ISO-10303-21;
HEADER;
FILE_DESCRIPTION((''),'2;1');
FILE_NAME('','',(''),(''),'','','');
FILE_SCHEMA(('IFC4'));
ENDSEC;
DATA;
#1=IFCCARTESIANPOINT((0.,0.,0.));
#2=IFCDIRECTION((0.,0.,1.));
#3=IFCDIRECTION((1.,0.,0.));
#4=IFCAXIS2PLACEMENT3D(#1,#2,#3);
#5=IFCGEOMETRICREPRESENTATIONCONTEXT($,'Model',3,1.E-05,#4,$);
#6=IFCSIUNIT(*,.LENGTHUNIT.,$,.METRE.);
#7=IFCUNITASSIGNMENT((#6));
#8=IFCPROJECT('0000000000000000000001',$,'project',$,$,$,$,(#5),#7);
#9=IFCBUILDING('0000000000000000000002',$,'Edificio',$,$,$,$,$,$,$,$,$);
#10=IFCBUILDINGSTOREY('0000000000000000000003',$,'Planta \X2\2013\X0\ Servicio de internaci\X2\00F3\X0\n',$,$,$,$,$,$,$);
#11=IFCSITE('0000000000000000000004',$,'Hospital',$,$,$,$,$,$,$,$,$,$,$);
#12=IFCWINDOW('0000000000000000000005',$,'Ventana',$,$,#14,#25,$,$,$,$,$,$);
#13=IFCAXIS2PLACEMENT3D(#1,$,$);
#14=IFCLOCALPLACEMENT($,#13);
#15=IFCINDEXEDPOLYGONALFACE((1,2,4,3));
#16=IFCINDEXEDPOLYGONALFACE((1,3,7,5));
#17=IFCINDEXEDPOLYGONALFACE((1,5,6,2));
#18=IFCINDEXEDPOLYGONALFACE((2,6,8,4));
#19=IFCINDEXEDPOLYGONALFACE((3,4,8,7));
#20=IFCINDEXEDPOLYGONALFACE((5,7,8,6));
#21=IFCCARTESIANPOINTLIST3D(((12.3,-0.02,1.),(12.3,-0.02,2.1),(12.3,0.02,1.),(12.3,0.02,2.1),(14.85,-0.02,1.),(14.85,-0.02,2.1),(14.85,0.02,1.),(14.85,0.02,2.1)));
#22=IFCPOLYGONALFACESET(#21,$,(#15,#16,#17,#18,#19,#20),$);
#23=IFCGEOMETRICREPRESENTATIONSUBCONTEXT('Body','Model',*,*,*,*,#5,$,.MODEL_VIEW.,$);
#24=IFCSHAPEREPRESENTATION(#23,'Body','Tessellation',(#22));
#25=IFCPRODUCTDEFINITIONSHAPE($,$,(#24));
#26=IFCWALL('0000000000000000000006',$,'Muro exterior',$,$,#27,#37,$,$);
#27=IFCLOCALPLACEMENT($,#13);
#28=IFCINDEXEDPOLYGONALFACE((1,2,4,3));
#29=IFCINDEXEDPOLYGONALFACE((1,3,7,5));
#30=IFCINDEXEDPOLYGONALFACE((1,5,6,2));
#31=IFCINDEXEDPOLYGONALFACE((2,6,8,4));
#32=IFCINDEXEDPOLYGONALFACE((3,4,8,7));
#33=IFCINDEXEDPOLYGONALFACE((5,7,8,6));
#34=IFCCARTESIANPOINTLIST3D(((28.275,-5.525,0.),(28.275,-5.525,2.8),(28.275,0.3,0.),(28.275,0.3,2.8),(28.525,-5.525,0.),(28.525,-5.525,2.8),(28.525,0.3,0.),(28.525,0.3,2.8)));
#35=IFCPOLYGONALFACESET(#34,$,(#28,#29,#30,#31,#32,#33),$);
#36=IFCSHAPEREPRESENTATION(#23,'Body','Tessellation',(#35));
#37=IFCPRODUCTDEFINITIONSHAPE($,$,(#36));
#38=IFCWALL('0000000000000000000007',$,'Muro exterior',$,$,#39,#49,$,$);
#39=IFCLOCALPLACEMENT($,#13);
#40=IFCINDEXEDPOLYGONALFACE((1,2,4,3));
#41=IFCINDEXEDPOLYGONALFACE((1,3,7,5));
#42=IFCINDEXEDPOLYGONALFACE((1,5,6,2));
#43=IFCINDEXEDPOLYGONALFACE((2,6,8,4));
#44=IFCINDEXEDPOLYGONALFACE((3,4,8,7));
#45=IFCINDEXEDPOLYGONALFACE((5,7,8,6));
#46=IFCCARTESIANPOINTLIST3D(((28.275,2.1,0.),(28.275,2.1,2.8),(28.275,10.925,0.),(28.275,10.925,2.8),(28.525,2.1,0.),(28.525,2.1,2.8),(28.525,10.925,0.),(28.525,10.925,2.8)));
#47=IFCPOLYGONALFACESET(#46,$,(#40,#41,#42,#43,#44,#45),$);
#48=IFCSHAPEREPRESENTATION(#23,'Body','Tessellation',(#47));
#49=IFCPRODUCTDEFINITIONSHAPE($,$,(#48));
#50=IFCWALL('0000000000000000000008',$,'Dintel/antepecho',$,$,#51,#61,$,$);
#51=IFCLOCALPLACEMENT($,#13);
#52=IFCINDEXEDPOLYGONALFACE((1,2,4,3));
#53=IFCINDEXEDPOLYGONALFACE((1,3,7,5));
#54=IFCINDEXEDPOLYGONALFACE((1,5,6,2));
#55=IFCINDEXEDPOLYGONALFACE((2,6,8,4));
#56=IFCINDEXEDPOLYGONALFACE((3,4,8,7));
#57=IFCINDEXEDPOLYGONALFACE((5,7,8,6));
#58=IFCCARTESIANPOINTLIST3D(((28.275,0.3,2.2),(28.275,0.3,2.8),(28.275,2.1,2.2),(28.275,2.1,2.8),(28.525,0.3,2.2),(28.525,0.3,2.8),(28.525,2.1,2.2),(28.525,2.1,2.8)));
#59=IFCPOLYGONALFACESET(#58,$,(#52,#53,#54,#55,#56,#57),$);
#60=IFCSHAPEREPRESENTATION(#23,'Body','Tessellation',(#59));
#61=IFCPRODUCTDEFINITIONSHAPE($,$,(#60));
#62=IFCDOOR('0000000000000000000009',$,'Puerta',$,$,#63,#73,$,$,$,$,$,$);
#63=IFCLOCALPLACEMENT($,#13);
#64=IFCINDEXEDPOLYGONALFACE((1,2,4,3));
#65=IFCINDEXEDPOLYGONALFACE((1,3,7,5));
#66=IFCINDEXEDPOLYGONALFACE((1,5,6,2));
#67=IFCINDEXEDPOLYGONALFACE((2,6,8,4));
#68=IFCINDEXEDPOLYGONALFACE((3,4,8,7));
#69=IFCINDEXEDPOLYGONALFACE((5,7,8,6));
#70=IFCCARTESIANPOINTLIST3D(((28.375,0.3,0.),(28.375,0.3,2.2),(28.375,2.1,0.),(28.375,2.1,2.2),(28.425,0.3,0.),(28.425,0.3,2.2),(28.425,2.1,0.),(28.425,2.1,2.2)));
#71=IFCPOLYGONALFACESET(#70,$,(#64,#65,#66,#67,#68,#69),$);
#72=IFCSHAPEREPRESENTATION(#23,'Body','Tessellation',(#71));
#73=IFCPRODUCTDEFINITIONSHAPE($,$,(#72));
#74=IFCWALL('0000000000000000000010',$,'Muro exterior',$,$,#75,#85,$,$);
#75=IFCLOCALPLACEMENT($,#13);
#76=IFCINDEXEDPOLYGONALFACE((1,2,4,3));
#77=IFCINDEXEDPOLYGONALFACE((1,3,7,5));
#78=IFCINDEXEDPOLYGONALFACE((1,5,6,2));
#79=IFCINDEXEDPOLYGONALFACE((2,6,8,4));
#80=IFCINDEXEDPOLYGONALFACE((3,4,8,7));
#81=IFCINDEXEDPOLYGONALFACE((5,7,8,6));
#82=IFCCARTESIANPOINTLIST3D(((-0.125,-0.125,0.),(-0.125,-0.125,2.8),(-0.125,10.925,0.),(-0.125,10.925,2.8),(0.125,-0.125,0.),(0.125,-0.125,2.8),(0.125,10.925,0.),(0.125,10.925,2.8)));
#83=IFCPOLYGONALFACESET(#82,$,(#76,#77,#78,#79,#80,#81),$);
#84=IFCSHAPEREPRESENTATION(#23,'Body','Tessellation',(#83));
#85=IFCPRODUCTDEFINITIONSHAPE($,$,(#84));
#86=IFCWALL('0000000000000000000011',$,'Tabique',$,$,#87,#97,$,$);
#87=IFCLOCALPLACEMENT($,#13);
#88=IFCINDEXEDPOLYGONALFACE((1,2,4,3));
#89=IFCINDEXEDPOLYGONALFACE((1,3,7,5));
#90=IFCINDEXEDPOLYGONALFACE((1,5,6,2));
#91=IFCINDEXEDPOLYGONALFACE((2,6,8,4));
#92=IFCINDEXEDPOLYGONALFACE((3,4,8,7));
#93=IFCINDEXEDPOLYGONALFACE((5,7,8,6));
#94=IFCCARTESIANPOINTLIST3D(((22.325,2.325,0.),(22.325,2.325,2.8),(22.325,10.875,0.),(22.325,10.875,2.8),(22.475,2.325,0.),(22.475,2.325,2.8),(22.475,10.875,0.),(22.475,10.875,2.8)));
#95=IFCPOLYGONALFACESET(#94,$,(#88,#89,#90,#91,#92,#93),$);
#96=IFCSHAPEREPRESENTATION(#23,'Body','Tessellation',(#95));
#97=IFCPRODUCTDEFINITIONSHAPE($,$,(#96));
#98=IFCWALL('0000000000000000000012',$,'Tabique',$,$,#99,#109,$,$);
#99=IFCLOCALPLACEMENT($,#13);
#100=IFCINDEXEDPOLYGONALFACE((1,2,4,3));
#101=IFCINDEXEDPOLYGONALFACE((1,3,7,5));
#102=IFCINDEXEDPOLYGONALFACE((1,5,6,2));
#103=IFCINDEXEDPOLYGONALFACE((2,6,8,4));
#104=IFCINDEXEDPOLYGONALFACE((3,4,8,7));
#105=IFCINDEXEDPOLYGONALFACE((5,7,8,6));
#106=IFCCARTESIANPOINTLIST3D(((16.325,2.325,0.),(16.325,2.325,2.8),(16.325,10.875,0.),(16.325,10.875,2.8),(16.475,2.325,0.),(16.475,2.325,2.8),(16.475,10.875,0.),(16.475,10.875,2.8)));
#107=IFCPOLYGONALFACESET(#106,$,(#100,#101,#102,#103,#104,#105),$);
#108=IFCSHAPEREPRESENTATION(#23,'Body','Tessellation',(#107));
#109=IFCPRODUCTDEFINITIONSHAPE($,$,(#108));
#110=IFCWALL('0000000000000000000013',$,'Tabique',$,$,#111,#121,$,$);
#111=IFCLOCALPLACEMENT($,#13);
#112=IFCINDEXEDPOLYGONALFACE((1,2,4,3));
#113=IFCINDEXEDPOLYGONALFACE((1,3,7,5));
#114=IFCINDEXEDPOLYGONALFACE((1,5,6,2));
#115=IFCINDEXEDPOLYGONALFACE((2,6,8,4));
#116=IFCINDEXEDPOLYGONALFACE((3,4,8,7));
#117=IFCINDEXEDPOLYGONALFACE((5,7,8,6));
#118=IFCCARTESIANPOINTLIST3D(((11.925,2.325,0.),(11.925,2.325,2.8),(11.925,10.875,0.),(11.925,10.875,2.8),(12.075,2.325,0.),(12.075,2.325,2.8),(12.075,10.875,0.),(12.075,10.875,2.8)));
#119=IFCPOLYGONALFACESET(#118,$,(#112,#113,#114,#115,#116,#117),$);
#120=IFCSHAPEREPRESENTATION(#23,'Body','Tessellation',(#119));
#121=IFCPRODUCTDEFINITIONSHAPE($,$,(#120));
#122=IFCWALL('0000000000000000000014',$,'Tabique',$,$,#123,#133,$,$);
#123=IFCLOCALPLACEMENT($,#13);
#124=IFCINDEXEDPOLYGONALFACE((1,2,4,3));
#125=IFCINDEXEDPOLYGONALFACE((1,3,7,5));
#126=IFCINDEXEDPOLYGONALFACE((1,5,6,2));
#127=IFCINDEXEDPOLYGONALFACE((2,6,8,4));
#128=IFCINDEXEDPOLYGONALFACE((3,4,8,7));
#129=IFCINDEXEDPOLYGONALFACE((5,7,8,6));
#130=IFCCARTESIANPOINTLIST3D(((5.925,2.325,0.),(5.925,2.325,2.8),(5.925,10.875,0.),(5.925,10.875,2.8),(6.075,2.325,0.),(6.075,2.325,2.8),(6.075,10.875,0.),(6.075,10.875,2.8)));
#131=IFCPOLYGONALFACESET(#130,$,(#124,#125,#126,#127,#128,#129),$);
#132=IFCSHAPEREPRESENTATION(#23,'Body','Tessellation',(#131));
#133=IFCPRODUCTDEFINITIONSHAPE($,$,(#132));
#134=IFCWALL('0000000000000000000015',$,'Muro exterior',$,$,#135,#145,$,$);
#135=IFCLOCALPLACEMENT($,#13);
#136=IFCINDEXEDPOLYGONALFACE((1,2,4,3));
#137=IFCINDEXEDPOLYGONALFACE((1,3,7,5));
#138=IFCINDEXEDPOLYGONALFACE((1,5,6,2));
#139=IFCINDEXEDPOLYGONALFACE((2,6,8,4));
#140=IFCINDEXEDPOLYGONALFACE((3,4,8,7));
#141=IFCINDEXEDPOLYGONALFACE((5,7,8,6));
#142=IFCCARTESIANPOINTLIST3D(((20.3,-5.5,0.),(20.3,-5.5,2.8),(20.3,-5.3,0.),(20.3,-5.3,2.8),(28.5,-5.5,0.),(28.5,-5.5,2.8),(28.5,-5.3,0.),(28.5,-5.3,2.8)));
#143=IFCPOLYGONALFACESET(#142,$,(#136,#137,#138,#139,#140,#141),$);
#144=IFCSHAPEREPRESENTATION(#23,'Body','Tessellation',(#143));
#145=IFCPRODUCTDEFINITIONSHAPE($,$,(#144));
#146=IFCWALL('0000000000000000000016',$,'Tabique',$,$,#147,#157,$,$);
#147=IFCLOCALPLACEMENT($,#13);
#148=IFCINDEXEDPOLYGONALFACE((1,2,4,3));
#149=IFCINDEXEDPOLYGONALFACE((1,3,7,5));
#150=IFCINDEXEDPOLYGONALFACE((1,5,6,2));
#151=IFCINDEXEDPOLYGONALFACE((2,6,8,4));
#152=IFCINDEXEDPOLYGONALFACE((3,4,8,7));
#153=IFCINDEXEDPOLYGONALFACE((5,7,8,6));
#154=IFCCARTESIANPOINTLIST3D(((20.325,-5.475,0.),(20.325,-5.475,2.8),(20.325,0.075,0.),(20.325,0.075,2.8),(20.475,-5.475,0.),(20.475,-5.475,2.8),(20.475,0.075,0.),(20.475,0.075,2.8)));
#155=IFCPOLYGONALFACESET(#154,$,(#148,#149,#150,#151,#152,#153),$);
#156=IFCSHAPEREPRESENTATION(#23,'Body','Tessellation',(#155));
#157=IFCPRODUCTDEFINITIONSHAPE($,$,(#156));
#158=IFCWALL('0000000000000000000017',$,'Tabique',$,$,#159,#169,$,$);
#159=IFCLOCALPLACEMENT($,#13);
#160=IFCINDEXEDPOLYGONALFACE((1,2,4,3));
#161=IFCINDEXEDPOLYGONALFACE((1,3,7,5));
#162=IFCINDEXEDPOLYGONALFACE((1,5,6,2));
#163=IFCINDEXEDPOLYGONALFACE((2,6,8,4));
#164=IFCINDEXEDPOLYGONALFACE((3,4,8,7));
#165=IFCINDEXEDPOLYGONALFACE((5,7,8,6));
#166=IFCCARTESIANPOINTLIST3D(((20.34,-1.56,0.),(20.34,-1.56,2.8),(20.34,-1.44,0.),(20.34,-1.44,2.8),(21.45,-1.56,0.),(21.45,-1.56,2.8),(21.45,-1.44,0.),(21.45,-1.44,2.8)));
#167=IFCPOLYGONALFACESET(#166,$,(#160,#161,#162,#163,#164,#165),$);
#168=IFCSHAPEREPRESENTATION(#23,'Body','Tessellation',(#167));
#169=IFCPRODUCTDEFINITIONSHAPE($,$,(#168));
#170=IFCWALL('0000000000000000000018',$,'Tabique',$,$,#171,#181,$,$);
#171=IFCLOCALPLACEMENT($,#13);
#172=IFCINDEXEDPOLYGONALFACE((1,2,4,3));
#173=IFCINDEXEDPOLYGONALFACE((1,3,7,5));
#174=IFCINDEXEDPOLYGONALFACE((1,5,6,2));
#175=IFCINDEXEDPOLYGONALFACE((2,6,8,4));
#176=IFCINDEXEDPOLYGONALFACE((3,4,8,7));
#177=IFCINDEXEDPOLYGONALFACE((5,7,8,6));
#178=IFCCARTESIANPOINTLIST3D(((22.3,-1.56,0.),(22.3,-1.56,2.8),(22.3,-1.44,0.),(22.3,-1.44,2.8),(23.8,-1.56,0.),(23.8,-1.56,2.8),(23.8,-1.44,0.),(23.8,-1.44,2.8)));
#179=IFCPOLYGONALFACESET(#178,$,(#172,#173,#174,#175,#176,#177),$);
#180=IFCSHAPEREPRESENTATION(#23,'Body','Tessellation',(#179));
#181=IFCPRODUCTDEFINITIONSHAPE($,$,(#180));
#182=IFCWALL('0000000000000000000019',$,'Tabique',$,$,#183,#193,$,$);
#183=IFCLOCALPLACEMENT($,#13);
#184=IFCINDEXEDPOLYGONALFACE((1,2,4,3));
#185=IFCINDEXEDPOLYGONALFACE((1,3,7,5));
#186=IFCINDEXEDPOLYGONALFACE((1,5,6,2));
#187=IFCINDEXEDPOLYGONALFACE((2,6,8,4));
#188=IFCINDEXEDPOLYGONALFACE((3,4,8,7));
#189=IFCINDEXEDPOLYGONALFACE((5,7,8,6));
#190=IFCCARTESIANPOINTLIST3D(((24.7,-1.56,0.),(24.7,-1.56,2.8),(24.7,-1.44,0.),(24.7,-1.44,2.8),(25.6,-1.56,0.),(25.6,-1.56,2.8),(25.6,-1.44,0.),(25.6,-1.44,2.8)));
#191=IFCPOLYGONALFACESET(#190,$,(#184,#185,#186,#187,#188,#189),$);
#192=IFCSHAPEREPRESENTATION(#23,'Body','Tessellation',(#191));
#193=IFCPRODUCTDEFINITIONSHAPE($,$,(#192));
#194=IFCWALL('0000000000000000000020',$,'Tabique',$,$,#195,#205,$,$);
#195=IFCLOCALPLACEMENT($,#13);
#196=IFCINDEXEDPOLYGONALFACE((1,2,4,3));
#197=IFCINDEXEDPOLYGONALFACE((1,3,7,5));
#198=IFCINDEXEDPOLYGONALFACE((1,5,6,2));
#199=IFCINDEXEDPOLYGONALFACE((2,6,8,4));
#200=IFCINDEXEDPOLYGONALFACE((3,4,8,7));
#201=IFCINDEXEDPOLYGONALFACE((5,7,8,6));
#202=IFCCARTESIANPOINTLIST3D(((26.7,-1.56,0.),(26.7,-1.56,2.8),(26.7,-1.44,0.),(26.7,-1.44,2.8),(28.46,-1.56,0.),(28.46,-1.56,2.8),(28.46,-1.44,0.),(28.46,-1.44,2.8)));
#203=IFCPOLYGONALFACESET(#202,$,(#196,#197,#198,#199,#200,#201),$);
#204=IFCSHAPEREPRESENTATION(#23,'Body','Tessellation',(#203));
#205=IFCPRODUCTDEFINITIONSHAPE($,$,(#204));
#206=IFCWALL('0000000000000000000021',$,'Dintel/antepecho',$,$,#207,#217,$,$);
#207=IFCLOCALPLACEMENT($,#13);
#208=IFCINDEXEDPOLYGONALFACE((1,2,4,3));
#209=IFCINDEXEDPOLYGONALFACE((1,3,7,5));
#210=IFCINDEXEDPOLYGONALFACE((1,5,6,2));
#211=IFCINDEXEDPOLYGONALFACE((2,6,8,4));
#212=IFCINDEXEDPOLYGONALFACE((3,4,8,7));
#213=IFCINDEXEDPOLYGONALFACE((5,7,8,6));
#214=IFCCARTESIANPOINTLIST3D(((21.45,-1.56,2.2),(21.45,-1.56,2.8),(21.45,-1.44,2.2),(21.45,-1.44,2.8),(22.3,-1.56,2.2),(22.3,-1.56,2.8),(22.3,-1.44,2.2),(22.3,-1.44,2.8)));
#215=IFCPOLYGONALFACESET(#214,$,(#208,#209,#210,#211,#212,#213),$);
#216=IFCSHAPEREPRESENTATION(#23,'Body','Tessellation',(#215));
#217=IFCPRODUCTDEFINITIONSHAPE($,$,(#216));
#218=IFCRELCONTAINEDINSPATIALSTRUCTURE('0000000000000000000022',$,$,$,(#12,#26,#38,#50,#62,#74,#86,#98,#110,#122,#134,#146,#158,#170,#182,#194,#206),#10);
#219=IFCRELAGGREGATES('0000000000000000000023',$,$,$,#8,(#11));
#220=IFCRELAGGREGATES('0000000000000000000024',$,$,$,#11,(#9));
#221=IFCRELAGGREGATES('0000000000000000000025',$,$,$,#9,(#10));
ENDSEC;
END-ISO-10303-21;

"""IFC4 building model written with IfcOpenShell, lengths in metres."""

from ifc_helpers import new_model, si_unit, frame, origin_with_axes, context, subcontext, project, spatial, line, indexed_curve, outline, extrude, element, save


model = new_model("IFC4")

# Units and contexts
model_context = context("Model", 3, precision=1e-05, world=origin_with_axes())
body_context = subcontext(model_context, "Body", "Model", "MODEL_VIEW")
ifc_project = project(units=[si_unit("LENGTHUNIT", "METRE")], contexts=[model_context])

# Site, building, storey
site = spatial("IfcSite", under=ifc_project, Name="Hospital")
building = spatial("IfcBuilding", under=site, Name="Edificio")
storey = spatial("IfcBuildingStorey", under=building, Name="Planta – Servicio de internación")

# Window
element("IfcWindow", 1, inside=storey, Name="Ventana", context=body_context, shape_type="SweptSolid", body=[
    extrude(outline(indexed_curve([(0.0, 0.0), (2.55, 0.0), (2.55, 0.04), (0.0, 0.04)], segments=[line(1, 2, 3, 4, 1)])), frame((12.3, -0.02, 1.0), z_axis=(0.0, 0.0, 1.0), x_axis=(1.0, 0.0, 0.0)), (0.0, 0.0, 1.0), 1.1),
])

# Walls
element("IfcWall", 2, inside=storey, Name="Muro exterior", context=body_context, shape_type="SweptSolid", body=[
    extrude(outline(indexed_curve([(0.0, 0.0), (0.25, 0.0), (0.25, 5.825), (0.0, 5.825)], segments=[line(1, 2, 3, 4, 1)])), frame((28.275, -5.525, 0.0), z_axis=(0.0, 0.0, 1.0), x_axis=(1.0, 0.0, 0.0)), (0.0, 0.0, 1.0), 2.8),
])
element("IfcWall", 3, inside=storey, Name="Muro exterior", context=body_context, shape_type="SweptSolid", body=[
    extrude(outline(indexed_curve([(0.0, 0.0), (0.25, 0.0), (0.25, 8.825), (0.0, 8.825)], segments=[line(1, 2, 3, 4, 1)])), frame((28.275, 2.1, 0.0), z_axis=(0.0, 0.0, 1.0), x_axis=(1.0, 0.0, 0.0)), (0.0, 0.0, 1.0), 2.8),
])
element("IfcWall", 4, inside=storey, Name="Dintel/antepecho", context=body_context, shape_type="SweptSolid", body=[
    extrude(outline(indexed_curve([(0.0, 0.0), (0.25, 0.0), (0.25, 1.8), (0.0, 1.8)], segments=[line(1, 2, 3, 4, 1)])), frame((28.275, 0.3, 2.2), z_axis=(0.0, 0.0, 1.0), x_axis=(1.0, 0.0, 0.0)), (0.0, 0.0, 1.0), 0.6),
])

# Door
element("IfcDoor", 5, inside=storey, Name="Puerta", context=body_context, shape_type="SweptSolid", body=[
    extrude(outline(indexed_curve([(0.0, 0.0), (0.05, 0.0), (0.05, 1.8), (0.0, 1.8)], segments=[line(1, 2, 3, 4, 1)])), frame((28.375, 0.3, 0.0), z_axis=(0.0, 0.0, 1.0), x_axis=(1.0, 0.0, 0.0)), (0.0, 0.0, 1.0), 2.2),
])

# Walls
element("IfcWall", 6, inside=storey, Name="Muro exterior", context=body_context, shape_type="SweptSolid", body=[
    extrude(outline(indexed_curve([(0.0, 0.0), (0.25, 0.0), (0.25, 11.05), (0.0, 11.05)], segments=[line(1, 2, 3, 4, 1)])), frame((-0.125, -0.125, 0.0), z_axis=(0.0, 0.0, 1.0), x_axis=(1.0, 0.0, 0.0)), (0.0, 0.0, 1.0), 2.8),
])
element("IfcWall", 7, inside=storey, Name="Tabique", context=body_context, shape_type="SweptSolid", body=[
    extrude(outline(indexed_curve([(0.0, 0.0), (0.15, 0.0), (0.15, 8.55), (0.0, 8.55)], segments=[line(1, 2, 3, 4, 1)])), frame((22.325, 2.325, 0.0), z_axis=(0.0, 0.0, 1.0), x_axis=(1.0, 0.0, 0.0)), (0.0, 0.0, 1.0), 2.8),
])
element("IfcWall", 8, inside=storey, Name="Tabique", context=body_context, shape_type="SweptSolid", body=[
    extrude(outline(indexed_curve([(0.0, 0.0), (0.15, 0.0), (0.15, 8.55), (0.0, 8.55)], segments=[line(1, 2, 3, 4, 1)])), frame((16.325, 2.325, 0.0), z_axis=(0.0, 0.0, 1.0), x_axis=(1.0, 0.0, 0.0)), (0.0, 0.0, 1.0), 2.8),
])
element("IfcWall", 9, inside=storey, Name="Tabique", context=body_context, shape_type="SweptSolid", body=[
    extrude(outline(indexed_curve([(0.0, 0.0), (0.15, 0.0), (0.15, 8.55), (0.0, 8.55)], segments=[line(1, 2, 3, 4, 1)])), frame((11.925, 2.325, 0.0), z_axis=(0.0, 0.0, 1.0), x_axis=(1.0, 0.0, 0.0)), (0.0, 0.0, 1.0), 2.8),
])
element("IfcWall", 10, inside=storey, Name="Tabique", context=body_context, shape_type="SweptSolid", body=[
    extrude(outline(indexed_curve([(0.0, 0.0), (0.15, 0.0), (0.15, 8.55), (0.0, 8.55)], segments=[line(1, 2, 3, 4, 1)])), frame((5.925, 2.325, 0.0), z_axis=(0.0, 0.0, 1.0), x_axis=(1.0, 0.0, 0.0)), (0.0, 0.0, 1.0), 2.8),
])
element("IfcWall", 11, inside=storey, Name="Muro exterior", context=body_context, shape_type="SweptSolid", body=[
    extrude(outline(indexed_curve([(0.0, 0.0), (8.2, 0.0), (8.2, 0.2), (0.0, 0.2)], segments=[line(1, 2, 3, 4, 1)])), frame((20.3, -5.5, 0.0), z_axis=(0.0, 0.0, 1.0), x_axis=(1.0, 0.0, 0.0)), (0.0, 0.0, 1.0), 2.8),
])
element("IfcWall", 12, inside=storey, Name="Tabique", context=body_context, shape_type="SweptSolid", body=[
    extrude(outline(indexed_curve([(0.0, 0.0), (0.15, 0.0), (0.15, 5.55), (0.0, 5.55)], segments=[line(1, 2, 3, 4, 1)])), frame((20.325, -5.475, 0.0), z_axis=(0.0, 0.0, 1.0), x_axis=(1.0, 0.0, 0.0)), (0.0, 0.0, 1.0), 2.8),
])
element("IfcWall", 13, inside=storey, Name="Tabique", context=body_context, shape_type="SweptSolid", body=[
    extrude(outline(indexed_curve([(0.0, 0.0), (1.11, 0.0), (1.11, 0.12), (0.0, 0.12)], segments=[line(1, 2, 3, 4, 1)])), frame((20.34, -1.56, 0.0), z_axis=(0.0, 0.0, 1.0), x_axis=(1.0, 0.0, 0.0)), (0.0, 0.0, 1.0), 2.8),
])
element("IfcWall", 14, inside=storey, Name="Tabique", context=body_context, shape_type="SweptSolid", body=[
    extrude(outline(indexed_curve([(0.0, 0.0), (1.5, 0.0), (1.5, 0.12), (0.0, 0.12)], segments=[line(1, 2, 3, 4, 1)])), frame((22.3, -1.56, 0.0), z_axis=(0.0, 0.0, 1.0), x_axis=(1.0, 0.0, 0.0)), (0.0, 0.0, 1.0), 2.8),
])
element("IfcWall", 15, inside=storey, Name="Tabique", context=body_context, shape_type="SweptSolid", body=[
    extrude(outline(indexed_curve([(0.0, 0.0), (0.9, 0.0), (0.9, 0.12), (0.0, 0.12)], segments=[line(1, 2, 3, 4, 1)])), frame((24.7, -1.56, 0.0), z_axis=(0.0, 0.0, 1.0), x_axis=(1.0, 0.0, 0.0)), (0.0, 0.0, 1.0), 2.8),
])
element("IfcWall", 16, inside=storey, Name="Tabique", context=body_context, shape_type="SweptSolid", body=[
    extrude(outline(indexed_curve([(0.0, 0.0), (1.76, 0.0), (1.76, 0.12), (0.0, 0.12)], segments=[line(1, 2, 3, 4, 1)])), frame((26.7, -1.56, 0.0), z_axis=(0.0, 0.0, 1.0), x_axis=(1.0, 0.0, 0.0)), (0.0, 0.0, 1.0), 2.8),
])
element("IfcWall", 17, inside=storey, Name="Dintel/antepecho", context=body_context, shape_type="SweptSolid", body=[
    extrude(outline(indexed_curve([(0.0, 0.0), (0.85, 0.0), (0.85, 0.12), (0.0, 0.12)], segments=[line(1, 2, 3, 4, 1)])), frame((21.45, -1.56, 2.2), z_axis=(0.0, 0.0, 1.0), x_axis=(1.0, 0.0, 0.0)), (0.0, 0.0, 1.0), 0.6),
])

save(model, "model.ifc")
